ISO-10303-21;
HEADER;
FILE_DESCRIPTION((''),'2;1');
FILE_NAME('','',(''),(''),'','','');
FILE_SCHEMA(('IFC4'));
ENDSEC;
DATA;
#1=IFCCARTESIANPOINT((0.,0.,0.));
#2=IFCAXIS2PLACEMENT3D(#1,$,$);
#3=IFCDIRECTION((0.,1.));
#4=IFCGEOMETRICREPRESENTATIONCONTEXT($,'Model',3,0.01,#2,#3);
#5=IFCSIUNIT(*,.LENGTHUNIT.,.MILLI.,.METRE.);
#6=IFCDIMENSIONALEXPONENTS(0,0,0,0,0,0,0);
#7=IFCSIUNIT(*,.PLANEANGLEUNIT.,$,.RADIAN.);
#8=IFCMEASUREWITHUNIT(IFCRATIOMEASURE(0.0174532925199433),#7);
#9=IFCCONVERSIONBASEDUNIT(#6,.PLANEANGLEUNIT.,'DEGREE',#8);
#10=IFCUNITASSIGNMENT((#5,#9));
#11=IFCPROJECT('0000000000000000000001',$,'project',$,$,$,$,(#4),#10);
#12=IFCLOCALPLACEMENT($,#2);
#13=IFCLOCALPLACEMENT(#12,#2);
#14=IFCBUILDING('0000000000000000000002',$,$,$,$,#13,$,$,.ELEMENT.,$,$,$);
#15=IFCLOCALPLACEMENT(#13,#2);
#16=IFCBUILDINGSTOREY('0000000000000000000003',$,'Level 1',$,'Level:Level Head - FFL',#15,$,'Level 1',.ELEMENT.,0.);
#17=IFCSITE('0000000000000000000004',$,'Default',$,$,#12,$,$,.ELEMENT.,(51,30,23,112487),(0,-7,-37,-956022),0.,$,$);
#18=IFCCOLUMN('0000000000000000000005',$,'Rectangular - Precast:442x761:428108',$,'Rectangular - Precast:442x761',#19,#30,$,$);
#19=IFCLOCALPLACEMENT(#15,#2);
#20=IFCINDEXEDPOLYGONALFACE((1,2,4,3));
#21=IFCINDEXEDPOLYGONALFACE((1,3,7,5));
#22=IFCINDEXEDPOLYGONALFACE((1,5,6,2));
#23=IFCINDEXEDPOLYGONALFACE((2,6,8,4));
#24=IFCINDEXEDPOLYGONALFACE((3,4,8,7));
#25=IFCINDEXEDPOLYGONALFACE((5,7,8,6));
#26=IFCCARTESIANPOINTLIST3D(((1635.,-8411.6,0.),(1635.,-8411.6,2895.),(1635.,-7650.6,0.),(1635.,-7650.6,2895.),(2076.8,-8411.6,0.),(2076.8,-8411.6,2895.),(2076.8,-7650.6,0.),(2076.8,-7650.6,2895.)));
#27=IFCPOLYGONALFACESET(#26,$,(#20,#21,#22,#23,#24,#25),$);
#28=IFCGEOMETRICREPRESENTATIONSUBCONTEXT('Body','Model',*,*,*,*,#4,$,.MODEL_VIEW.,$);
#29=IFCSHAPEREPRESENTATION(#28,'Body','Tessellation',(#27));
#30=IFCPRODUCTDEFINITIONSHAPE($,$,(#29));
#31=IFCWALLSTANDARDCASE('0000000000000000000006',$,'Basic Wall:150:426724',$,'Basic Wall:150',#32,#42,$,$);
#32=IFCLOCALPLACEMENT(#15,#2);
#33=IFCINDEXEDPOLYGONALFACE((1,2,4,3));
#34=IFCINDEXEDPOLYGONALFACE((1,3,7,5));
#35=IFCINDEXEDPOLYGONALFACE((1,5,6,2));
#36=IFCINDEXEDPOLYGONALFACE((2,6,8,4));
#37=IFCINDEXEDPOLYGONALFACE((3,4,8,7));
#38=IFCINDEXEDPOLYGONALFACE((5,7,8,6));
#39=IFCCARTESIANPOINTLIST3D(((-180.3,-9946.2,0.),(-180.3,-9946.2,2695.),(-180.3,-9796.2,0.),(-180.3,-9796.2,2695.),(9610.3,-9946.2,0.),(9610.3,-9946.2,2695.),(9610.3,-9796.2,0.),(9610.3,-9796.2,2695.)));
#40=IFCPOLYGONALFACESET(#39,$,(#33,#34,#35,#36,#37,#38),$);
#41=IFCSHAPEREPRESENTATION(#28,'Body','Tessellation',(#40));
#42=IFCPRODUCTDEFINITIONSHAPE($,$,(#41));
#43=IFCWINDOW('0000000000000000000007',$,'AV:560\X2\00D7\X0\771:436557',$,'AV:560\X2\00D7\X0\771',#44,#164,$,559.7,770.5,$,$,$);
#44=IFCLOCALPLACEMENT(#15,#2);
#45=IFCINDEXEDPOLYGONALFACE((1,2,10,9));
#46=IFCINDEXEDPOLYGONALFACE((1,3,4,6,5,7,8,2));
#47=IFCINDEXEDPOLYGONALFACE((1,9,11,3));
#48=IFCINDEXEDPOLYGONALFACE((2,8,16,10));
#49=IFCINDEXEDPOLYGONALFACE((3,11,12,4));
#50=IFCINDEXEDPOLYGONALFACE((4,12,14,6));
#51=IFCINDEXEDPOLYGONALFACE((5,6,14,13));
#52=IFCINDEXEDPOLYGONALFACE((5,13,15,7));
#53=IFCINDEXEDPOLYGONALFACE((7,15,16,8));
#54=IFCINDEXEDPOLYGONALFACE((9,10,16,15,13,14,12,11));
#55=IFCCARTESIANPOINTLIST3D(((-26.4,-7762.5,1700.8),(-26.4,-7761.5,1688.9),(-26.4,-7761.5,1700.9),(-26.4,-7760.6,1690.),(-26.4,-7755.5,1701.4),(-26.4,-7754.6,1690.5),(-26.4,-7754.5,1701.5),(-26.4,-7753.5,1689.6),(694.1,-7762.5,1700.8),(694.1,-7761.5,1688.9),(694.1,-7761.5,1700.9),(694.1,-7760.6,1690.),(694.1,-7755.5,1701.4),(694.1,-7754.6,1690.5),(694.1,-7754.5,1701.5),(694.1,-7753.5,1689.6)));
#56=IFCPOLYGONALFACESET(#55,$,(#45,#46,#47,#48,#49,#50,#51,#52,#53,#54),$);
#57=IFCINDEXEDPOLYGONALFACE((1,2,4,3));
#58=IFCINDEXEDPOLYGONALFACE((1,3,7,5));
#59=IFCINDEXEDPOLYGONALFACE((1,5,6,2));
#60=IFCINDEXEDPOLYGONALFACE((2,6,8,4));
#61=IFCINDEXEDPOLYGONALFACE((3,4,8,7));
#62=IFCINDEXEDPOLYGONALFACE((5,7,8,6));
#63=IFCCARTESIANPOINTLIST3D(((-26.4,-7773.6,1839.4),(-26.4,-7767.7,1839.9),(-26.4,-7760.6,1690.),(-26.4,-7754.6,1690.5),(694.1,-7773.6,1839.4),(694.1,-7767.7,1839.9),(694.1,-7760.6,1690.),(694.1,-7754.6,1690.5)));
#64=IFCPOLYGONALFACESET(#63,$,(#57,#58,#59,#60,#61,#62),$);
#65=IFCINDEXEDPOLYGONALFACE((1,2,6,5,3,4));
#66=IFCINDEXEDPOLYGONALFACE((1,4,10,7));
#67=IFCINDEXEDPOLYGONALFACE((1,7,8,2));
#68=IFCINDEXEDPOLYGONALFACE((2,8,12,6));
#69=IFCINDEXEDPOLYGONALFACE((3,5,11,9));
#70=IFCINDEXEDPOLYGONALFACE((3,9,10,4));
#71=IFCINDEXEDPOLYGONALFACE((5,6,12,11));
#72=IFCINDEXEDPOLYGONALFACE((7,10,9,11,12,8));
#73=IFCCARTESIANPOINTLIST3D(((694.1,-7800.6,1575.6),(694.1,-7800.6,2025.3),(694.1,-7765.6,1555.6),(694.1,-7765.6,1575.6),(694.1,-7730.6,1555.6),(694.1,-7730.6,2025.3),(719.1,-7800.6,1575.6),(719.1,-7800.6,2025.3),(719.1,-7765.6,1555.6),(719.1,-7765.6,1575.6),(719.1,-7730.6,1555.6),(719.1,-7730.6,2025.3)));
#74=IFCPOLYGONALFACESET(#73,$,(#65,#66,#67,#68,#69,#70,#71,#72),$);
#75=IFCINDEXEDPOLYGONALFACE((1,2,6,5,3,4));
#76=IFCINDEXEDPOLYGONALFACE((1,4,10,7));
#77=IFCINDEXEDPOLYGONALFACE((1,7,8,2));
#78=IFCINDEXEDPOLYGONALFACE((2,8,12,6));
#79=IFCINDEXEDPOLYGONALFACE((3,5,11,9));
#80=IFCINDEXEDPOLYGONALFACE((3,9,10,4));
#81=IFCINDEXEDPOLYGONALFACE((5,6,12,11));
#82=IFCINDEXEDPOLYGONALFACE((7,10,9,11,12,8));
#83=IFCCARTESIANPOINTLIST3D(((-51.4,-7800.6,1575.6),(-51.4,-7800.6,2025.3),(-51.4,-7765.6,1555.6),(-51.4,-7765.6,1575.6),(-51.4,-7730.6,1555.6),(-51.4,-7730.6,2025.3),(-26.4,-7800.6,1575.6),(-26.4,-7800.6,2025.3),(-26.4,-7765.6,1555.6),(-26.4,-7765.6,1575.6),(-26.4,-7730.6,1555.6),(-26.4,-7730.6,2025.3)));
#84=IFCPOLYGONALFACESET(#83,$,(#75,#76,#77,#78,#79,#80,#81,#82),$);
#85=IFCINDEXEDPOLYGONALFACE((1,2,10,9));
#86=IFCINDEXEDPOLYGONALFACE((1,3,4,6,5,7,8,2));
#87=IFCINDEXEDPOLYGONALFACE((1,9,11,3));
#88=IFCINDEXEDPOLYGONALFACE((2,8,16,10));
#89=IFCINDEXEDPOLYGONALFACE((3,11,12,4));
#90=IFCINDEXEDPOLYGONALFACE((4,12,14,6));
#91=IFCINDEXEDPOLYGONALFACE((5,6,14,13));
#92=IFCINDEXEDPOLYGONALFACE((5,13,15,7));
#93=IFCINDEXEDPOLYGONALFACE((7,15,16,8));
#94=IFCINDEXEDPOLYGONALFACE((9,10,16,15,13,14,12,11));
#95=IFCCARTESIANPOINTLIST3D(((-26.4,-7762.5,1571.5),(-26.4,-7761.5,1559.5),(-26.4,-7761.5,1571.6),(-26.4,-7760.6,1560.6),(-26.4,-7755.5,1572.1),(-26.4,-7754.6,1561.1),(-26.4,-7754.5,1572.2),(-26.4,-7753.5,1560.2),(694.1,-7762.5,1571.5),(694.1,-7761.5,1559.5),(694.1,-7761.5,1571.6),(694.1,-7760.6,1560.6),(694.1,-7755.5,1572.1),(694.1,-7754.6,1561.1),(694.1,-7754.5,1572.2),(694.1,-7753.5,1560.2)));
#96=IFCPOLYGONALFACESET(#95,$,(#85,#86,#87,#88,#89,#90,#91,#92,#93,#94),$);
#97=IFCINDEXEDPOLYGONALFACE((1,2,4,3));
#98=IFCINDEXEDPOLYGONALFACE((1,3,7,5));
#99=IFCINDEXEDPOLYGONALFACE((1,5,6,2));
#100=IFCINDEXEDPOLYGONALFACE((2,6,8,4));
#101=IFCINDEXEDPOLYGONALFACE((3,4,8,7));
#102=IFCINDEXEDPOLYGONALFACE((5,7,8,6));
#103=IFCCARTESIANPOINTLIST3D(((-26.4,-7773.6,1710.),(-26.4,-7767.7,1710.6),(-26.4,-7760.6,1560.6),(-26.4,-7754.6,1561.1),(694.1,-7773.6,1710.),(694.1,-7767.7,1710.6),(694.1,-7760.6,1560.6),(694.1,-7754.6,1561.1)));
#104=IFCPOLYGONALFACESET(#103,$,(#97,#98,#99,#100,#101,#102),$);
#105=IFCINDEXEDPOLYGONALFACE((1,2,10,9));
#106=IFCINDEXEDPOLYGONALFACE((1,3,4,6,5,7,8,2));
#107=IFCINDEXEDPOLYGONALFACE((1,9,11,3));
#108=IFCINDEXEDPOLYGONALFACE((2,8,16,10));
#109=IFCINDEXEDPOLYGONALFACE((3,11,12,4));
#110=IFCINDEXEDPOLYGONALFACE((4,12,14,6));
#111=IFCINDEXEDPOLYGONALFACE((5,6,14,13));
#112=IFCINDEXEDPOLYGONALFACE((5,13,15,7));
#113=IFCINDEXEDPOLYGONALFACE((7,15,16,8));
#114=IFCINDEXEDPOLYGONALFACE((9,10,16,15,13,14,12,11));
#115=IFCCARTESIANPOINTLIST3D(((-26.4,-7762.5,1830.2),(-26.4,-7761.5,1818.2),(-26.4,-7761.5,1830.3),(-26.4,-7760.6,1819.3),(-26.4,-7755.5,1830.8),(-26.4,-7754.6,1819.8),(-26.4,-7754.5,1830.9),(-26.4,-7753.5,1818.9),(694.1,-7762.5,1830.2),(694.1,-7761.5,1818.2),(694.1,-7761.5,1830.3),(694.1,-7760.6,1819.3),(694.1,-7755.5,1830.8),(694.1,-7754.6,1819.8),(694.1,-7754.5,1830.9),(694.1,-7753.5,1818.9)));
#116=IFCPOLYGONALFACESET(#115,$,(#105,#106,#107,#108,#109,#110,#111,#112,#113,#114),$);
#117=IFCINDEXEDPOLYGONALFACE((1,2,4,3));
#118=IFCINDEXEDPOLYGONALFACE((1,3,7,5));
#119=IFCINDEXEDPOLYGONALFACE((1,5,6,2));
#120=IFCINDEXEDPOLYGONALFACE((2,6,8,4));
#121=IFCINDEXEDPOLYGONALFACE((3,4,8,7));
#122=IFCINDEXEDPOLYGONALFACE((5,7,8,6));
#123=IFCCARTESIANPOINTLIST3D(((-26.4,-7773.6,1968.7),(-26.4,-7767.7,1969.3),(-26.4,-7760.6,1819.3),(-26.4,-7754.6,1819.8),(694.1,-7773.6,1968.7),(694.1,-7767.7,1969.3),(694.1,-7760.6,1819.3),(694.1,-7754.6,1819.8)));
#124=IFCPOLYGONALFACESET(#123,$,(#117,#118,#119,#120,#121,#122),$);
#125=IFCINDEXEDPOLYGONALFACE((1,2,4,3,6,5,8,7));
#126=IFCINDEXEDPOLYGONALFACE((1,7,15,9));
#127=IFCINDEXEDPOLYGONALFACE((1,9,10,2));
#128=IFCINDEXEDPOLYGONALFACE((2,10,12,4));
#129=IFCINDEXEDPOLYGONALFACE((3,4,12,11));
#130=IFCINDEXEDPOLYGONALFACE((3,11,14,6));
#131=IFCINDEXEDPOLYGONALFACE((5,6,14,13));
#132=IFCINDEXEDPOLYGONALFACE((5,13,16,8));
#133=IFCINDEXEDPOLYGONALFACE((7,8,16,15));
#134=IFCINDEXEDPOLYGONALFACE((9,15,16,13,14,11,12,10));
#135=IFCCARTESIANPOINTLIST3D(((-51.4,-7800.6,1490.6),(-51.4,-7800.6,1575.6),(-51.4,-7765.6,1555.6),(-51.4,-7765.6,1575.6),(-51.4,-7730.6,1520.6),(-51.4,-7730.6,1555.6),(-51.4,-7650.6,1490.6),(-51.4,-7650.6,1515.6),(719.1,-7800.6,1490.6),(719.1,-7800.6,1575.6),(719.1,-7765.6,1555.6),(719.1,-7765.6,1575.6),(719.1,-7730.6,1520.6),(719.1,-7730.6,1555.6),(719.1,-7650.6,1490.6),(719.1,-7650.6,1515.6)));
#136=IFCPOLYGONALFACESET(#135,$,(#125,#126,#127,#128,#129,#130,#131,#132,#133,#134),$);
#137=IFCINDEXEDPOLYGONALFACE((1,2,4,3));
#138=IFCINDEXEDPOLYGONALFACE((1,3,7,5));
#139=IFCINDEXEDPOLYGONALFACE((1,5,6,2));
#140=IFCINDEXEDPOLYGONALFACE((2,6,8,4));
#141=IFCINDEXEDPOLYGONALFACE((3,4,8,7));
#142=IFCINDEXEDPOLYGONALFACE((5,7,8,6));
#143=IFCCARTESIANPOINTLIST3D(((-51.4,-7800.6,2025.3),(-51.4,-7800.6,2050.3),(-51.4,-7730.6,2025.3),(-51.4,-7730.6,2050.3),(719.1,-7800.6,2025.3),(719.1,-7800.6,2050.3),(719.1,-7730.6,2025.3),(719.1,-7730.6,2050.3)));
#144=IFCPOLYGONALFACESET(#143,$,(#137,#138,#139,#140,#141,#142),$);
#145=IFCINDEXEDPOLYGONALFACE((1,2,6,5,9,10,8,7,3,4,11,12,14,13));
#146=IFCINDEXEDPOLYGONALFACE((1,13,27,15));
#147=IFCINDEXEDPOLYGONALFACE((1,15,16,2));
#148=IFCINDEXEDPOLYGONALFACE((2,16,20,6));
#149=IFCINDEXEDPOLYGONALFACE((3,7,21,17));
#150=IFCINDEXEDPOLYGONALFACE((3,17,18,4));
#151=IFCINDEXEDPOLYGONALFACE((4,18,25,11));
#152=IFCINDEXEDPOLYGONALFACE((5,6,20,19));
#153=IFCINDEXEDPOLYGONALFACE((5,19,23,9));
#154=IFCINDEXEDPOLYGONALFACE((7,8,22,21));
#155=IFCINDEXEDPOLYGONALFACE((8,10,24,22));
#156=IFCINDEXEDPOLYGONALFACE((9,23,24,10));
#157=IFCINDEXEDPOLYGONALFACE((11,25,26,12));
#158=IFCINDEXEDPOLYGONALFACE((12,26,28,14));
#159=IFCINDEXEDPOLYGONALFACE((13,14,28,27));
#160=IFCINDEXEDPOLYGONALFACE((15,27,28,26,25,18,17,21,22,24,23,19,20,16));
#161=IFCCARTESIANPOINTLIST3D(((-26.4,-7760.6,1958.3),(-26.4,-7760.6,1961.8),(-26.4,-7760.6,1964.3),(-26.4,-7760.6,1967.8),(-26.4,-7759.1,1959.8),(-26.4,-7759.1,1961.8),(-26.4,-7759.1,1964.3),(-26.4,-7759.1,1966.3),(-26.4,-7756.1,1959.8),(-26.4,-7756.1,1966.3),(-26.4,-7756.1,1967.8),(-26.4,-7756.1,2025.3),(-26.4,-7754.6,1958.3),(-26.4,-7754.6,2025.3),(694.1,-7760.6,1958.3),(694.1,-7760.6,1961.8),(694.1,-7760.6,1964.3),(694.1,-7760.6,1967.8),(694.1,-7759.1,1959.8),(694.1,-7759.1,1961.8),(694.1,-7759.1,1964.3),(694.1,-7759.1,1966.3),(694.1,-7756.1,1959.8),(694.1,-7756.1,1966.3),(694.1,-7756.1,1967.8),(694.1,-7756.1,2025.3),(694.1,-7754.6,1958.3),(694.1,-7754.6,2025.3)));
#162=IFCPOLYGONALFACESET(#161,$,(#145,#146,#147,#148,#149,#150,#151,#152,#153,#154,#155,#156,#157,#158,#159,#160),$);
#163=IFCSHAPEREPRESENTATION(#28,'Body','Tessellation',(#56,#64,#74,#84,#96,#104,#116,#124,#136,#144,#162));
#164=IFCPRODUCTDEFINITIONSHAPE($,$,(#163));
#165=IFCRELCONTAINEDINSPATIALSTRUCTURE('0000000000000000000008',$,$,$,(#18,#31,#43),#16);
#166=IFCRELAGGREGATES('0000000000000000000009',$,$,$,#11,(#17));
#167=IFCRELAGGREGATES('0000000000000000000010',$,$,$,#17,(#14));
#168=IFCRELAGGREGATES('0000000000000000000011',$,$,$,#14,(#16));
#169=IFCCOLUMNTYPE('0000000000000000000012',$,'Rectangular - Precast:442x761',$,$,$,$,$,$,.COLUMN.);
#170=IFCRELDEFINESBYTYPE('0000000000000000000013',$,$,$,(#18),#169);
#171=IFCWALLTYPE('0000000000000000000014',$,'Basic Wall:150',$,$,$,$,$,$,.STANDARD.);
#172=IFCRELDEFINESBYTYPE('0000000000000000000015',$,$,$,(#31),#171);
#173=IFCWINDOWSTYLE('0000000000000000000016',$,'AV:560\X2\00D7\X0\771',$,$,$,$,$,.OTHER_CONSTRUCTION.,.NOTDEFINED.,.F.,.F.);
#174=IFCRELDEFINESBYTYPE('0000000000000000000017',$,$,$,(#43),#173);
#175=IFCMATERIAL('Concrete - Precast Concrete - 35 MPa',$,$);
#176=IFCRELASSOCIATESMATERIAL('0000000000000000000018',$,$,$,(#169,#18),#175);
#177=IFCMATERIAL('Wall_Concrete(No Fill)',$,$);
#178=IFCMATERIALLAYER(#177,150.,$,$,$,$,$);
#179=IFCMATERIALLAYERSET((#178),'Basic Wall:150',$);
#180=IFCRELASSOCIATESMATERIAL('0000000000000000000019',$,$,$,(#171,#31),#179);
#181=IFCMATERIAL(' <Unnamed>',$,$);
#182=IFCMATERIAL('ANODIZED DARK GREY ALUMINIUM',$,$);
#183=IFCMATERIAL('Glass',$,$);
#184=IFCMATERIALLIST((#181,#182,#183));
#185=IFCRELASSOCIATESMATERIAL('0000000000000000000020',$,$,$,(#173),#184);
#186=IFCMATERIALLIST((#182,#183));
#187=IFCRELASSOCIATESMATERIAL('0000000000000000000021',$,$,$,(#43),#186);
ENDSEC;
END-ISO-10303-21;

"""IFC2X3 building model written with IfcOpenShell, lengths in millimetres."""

from ifc_helpers import new_model, entity, si_unit, converted_unit, direction, frame, frame_2d, origin, origin_2d_with_axis, place, context, subcontext, project, spatial, polyline, rectangle, outline, extrude, source, transform, mapped, material, material_list, layer, layer_set, layer_usage, type_object, type_shapes, element, save


model = new_model("IFC2X3")

# Units and contexts
model_context = context("Model", 3, precision=0.01, world=origin(), true_north=direction((0.0, 1.0)))
body_context = subcontext(model_context, "Body", "Model", "MODEL_VIEW")
ifc_project = project(units=[si_unit("LENGTHUNIT", "METRE", prefix="MILLI"), converted_unit("PLANEANGLEUNIT", "DEGREE", entity("IfcRatioMeasure", 0.0174532925199433), si_unit("PLANEANGLEUNIT", "RADIAN"), dimensions=[0, 0, 0, 0, 0, 0, 0])], contexts=[model_context])

# Site, building, storey
site_placement = place(None, origin())
site = spatial("IfcSite", under=ifc_project, at=site_placement, Name="Default", CompositionType="ELEMENT", RefLatitude=(51, 30, 23, 112487), RefLongitude=(0, -7, -37, -956022), RefElevation=0.0)
building_placement = place(site_placement, origin())
building = spatial("IfcBuilding", under=site, at=building_placement, CompositionType="ELEMENT")
storey_placement = place(building_placement, origin())
storey = spatial("IfcBuildingStorey", under=building, at=storey_placement, Name="Level 1", ObjectType="Level:Level Head - FFL", LongName="Level 1", CompositionType="ELEMENT", Elevation=0.0)

# Column
ifc_material_1 = material(Name="Concrete - Precast Concrete - 35 MPa")
column_type = type_object("IfcColumnType", Name="Rectangular - Precast:442x761", PredefinedType="COLUMN", material=ifc_material_1)
shared_shape_1 = source(origin(), body_context, "Body", "SweptSolid", [
    extrude(rectangle(XDim=761.0, YDim=441.8, at=frame_2d((0.0, 0.0), x_axis=(1.0, 0.0))), frame((0.0, 0.0, 0.0), z_axis=(0.0, 0.0, 1.0), x_axis=(0.0, -1.0, 0.0)), (0.0, 0.0, 1.0), 2895.0),
])
type_shapes(column_type, [shared_shape_1])
column_placement = place(storey_placement, frame((1855.9, -8031.1, 0.0)))
element("IfcColumn", 1, at=column_placement, inside=storey, type_object=column_type, material=ifc_material_1, Name="Rectangular - Precast:442x761:428108", ObjectType="Rectangular - Precast:442x761", context=body_context, shape_type="MappedRepresentation", body=[
    mapped(shared_shape_1, transform((0.0, 0.0, 0.0), scale=1.0)),
])

# Shared definitions
ifc_material_2 = material(Name="Wall_Concrete(No Fill)")

# Wall
ifc_layer_1 = layer(ifc_material_2, 150.0)
ifc_layer_set_1 = layer_set([ifc_layer_1], Name="Basic Wall:150")
ifc_layer_usage_1 = layer_usage(ifc_layer_set_1, "AXIS2", "NEGATIVE", 75.0)
wall_type_1 = type_object("IfcWallType", Name="Basic Wall:150", PredefinedType="STANDARD", material=ifc_layer_set_1)
wall_1_placement = place(storey_placement, frame((-180.3, -9871.2, 0.0)))
element("IfcWallStandardCase", 2, at=wall_1_placement, inside=storey, type_object=wall_type_1, material=ifc_layer_usage_1, Name="Basic Wall:150:426724", ObjectType="Basic Wall:150", context=body_context, shape_type="SweptSolid", body=[
    extrude(rectangle(XDim=9790.6, YDim=150.0, at=frame_2d((4895.3, 0.0), x_axis=(-1.0, 0.0))), origin(), (0.0, 0.0, 1.0), 2695.0),
])

# Window
ifc_material_3 = material(Name="ANODIZED DARK GREY ALUMINIUM")
ifc_material_4 = material(Name="Glass")
ifc_material_list_1 = material_list([ifc_material_3, ifc_material_4])
ifc_material_5 = material(Name=" <Unnamed>")
ifc_material_list_2 = material_list([ifc_material_5, ifc_material_3, ifc_material_4])
window_style = type_object("IfcWindowStyle", Name="AV:560×771", ConstructionType="OTHER_CONSTRUCTION", OperationType="NOTDEFINED", ParameterTakesPrecedence=False, Sizeable=False, material=ifc_material_list_2)
shared_shape_2 = source(origin(), body_context, "Body", "SweptSolid", [
    extrude(outline(polyline([(-5.8, -3.0), (-5.8, -4.0), (6.3, -4.0), (6.3, 4.0), (-5.8, 4.0), (-5.8, 3.0), (5.2, 3.0), (5.2, -3.0), (-5.8, -3.0)])), frame((25.0, 42.5, 204.8), z_axis=(-1.0, 0.0, 0.0), x_axis=(0.0, 0.087156, -0.996195)), (0.0, 0.0, -1.0), 720.5),
    extrude(rectangle(XDim=150.0, YDim=6.0, at=frame_2d((0.0, 0.0), x_axis=(1.0, 0.0))), frame((25.0, 36.5, 274.3), z_axis=(1.0, 0.0, 0.0), x_axis=(0.0, 0.087156, -0.996195)), (0.0, 0.0, 1.0), 720.5),
    extrude(outline(polyline([(-306.4, -35.0), (143.2, -35.0), (143.2, 0.0), (163.2, 0.0), (163.2, 35.0), (-306.4, 35.0), (-306.4, -35.0)])), frame((745.5, 35.0, 228.2), z_axis=(1.0, 0.0, 0.0), x_axis=(0.0, 0.0, -1.0)), (0.0, 0.0, 1.0), 25.0),
    extrude(outline(polyline([(-306.4, -35.0), (143.2, -35.0), (143.2, 0.0), (163.2, 0.0), (163.2, 35.0), (-306.4, 35.0), (-306.4, -35.0)])), frame((0.0, 35.0, 228.2), z_axis=(1.0, 0.0, 0.0), x_axis=(0.0, 0.0, -1.0)), (0.0, 0.0, 1.0), 25.0),
    extrude(outline(polyline([(-5.8, -3.0), (-5.8, -4.0), (6.3, -4.0), (6.3, 4.0), (-5.8, 4.0), (-5.8, 3.0), (5.2, 3.0), (5.2, -3.0), (-5.8, -3.0)])), frame((25.0, 42.5, 75.5), z_axis=(-1.0, 0.0, 0.0), x_axis=(0.0, 0.087156, -0.996195)), (0.0, 0.0, -1.0), 720.5),
    extrude(rectangle(XDim=150.0, YDim=6.0, at=frame_2d((0.0, 0.0), x_axis=(1.0, 0.0))), frame((25.0, 36.5, 145.0), z_axis=(1.0, 0.0, 0.0), x_axis=(0.0, 0.087156, -0.996195)), (0.0, 0.0, 1.0), 720.5),
    extrude(outline(polyline([(-5.8, -3.0), (-5.8, -4.0), (6.3, -4.0), (6.3, 4.0), (-5.8, 4.0), (-5.8, 3.0), (5.2, 3.0), (5.2, -3.0), (-5.8, -3.0)])), frame((25.0, 42.5, 334.2), z_axis=(-1.0, 0.0, 0.0), x_axis=(0.0, 0.087156, -0.996195)), (0.0, 0.0, -1.0), 720.5),
    extrude(rectangle(XDim=150.0, YDim=6.0, at=frame_2d((0.0, 0.0), x_axis=(1.0, 0.0))), frame((25.0, 36.5, 403.7), z_axis=(1.0, 0.0, 0.0), x_axis=(0.0, 0.087156, -0.996195)), (0.0, 0.0, 1.0), 720.5),
    extrude(outline(polyline([(-63.8, -44.4), (86.3, -44.4), (86.3, -19.4), (6.2, -14.4), (6.2, 20.6), (-28.8, 20.6), (-28.8, 40.6), (-63.8, 40.6), (-63.8, -44.4)])), frame((0.0, 63.8, 44.4), z_axis=(1.0, 0.0, 0.0), x_axis=(0.0, 1.0, 0.0)), (0.0, 0.0, 1.0), 770.5),
    extrude(rectangle(XDim=70.0, YDim=770.5, at=origin_2d_with_axis()), frame((385.3, 35.0, 534.7), z_axis=(0.0, 0.0, 1.0), x_axis=(0.0, -1.0, 0.0)), (0.0, 0.0, 1.0), 25.0),
    extrude(outline(polyline([(-3.4, -53.4), (-1.9, -53.4), (-1.9, 4.1), (2.6, 4.1), (2.6, 7.6), (1.1, 7.6), (1.1, 5.6), (-1.9, 5.6), (-1.9, 12.1), (1.1, 12.1), (1.1, 10.1), (2.6, 10.1), (2.6, 13.6), (-3.4, 13.6), (-3.4, -53.4)])), frame((25.0, 42.6, 481.3), z_axis=(1.0, 0.0, 0.0), x_axis=(0.0, -1.0, 0.0)), (0.0, 0.0, 1.0), 720.5),
])
type_shapes(window_style, [shared_shape_2])
window_placement = place(storey_placement, frame((-51.4, -7800.6, 1490.6)))
element("IfcWindow", 3, at=window_placement, inside=storey, type_object=window_style, material=ifc_material_list_1, Name="AV:560×771:436557", ObjectType="AV:560×771", OverallHeight=559.7, OverallWidth=770.5, context=body_context, shape_type="MappedRepresentation", body=[
    mapped(shared_shape_2, transform((0.0, 0.0, 0.0), scale=1.0)),
])

save(model, "model.ifc")
